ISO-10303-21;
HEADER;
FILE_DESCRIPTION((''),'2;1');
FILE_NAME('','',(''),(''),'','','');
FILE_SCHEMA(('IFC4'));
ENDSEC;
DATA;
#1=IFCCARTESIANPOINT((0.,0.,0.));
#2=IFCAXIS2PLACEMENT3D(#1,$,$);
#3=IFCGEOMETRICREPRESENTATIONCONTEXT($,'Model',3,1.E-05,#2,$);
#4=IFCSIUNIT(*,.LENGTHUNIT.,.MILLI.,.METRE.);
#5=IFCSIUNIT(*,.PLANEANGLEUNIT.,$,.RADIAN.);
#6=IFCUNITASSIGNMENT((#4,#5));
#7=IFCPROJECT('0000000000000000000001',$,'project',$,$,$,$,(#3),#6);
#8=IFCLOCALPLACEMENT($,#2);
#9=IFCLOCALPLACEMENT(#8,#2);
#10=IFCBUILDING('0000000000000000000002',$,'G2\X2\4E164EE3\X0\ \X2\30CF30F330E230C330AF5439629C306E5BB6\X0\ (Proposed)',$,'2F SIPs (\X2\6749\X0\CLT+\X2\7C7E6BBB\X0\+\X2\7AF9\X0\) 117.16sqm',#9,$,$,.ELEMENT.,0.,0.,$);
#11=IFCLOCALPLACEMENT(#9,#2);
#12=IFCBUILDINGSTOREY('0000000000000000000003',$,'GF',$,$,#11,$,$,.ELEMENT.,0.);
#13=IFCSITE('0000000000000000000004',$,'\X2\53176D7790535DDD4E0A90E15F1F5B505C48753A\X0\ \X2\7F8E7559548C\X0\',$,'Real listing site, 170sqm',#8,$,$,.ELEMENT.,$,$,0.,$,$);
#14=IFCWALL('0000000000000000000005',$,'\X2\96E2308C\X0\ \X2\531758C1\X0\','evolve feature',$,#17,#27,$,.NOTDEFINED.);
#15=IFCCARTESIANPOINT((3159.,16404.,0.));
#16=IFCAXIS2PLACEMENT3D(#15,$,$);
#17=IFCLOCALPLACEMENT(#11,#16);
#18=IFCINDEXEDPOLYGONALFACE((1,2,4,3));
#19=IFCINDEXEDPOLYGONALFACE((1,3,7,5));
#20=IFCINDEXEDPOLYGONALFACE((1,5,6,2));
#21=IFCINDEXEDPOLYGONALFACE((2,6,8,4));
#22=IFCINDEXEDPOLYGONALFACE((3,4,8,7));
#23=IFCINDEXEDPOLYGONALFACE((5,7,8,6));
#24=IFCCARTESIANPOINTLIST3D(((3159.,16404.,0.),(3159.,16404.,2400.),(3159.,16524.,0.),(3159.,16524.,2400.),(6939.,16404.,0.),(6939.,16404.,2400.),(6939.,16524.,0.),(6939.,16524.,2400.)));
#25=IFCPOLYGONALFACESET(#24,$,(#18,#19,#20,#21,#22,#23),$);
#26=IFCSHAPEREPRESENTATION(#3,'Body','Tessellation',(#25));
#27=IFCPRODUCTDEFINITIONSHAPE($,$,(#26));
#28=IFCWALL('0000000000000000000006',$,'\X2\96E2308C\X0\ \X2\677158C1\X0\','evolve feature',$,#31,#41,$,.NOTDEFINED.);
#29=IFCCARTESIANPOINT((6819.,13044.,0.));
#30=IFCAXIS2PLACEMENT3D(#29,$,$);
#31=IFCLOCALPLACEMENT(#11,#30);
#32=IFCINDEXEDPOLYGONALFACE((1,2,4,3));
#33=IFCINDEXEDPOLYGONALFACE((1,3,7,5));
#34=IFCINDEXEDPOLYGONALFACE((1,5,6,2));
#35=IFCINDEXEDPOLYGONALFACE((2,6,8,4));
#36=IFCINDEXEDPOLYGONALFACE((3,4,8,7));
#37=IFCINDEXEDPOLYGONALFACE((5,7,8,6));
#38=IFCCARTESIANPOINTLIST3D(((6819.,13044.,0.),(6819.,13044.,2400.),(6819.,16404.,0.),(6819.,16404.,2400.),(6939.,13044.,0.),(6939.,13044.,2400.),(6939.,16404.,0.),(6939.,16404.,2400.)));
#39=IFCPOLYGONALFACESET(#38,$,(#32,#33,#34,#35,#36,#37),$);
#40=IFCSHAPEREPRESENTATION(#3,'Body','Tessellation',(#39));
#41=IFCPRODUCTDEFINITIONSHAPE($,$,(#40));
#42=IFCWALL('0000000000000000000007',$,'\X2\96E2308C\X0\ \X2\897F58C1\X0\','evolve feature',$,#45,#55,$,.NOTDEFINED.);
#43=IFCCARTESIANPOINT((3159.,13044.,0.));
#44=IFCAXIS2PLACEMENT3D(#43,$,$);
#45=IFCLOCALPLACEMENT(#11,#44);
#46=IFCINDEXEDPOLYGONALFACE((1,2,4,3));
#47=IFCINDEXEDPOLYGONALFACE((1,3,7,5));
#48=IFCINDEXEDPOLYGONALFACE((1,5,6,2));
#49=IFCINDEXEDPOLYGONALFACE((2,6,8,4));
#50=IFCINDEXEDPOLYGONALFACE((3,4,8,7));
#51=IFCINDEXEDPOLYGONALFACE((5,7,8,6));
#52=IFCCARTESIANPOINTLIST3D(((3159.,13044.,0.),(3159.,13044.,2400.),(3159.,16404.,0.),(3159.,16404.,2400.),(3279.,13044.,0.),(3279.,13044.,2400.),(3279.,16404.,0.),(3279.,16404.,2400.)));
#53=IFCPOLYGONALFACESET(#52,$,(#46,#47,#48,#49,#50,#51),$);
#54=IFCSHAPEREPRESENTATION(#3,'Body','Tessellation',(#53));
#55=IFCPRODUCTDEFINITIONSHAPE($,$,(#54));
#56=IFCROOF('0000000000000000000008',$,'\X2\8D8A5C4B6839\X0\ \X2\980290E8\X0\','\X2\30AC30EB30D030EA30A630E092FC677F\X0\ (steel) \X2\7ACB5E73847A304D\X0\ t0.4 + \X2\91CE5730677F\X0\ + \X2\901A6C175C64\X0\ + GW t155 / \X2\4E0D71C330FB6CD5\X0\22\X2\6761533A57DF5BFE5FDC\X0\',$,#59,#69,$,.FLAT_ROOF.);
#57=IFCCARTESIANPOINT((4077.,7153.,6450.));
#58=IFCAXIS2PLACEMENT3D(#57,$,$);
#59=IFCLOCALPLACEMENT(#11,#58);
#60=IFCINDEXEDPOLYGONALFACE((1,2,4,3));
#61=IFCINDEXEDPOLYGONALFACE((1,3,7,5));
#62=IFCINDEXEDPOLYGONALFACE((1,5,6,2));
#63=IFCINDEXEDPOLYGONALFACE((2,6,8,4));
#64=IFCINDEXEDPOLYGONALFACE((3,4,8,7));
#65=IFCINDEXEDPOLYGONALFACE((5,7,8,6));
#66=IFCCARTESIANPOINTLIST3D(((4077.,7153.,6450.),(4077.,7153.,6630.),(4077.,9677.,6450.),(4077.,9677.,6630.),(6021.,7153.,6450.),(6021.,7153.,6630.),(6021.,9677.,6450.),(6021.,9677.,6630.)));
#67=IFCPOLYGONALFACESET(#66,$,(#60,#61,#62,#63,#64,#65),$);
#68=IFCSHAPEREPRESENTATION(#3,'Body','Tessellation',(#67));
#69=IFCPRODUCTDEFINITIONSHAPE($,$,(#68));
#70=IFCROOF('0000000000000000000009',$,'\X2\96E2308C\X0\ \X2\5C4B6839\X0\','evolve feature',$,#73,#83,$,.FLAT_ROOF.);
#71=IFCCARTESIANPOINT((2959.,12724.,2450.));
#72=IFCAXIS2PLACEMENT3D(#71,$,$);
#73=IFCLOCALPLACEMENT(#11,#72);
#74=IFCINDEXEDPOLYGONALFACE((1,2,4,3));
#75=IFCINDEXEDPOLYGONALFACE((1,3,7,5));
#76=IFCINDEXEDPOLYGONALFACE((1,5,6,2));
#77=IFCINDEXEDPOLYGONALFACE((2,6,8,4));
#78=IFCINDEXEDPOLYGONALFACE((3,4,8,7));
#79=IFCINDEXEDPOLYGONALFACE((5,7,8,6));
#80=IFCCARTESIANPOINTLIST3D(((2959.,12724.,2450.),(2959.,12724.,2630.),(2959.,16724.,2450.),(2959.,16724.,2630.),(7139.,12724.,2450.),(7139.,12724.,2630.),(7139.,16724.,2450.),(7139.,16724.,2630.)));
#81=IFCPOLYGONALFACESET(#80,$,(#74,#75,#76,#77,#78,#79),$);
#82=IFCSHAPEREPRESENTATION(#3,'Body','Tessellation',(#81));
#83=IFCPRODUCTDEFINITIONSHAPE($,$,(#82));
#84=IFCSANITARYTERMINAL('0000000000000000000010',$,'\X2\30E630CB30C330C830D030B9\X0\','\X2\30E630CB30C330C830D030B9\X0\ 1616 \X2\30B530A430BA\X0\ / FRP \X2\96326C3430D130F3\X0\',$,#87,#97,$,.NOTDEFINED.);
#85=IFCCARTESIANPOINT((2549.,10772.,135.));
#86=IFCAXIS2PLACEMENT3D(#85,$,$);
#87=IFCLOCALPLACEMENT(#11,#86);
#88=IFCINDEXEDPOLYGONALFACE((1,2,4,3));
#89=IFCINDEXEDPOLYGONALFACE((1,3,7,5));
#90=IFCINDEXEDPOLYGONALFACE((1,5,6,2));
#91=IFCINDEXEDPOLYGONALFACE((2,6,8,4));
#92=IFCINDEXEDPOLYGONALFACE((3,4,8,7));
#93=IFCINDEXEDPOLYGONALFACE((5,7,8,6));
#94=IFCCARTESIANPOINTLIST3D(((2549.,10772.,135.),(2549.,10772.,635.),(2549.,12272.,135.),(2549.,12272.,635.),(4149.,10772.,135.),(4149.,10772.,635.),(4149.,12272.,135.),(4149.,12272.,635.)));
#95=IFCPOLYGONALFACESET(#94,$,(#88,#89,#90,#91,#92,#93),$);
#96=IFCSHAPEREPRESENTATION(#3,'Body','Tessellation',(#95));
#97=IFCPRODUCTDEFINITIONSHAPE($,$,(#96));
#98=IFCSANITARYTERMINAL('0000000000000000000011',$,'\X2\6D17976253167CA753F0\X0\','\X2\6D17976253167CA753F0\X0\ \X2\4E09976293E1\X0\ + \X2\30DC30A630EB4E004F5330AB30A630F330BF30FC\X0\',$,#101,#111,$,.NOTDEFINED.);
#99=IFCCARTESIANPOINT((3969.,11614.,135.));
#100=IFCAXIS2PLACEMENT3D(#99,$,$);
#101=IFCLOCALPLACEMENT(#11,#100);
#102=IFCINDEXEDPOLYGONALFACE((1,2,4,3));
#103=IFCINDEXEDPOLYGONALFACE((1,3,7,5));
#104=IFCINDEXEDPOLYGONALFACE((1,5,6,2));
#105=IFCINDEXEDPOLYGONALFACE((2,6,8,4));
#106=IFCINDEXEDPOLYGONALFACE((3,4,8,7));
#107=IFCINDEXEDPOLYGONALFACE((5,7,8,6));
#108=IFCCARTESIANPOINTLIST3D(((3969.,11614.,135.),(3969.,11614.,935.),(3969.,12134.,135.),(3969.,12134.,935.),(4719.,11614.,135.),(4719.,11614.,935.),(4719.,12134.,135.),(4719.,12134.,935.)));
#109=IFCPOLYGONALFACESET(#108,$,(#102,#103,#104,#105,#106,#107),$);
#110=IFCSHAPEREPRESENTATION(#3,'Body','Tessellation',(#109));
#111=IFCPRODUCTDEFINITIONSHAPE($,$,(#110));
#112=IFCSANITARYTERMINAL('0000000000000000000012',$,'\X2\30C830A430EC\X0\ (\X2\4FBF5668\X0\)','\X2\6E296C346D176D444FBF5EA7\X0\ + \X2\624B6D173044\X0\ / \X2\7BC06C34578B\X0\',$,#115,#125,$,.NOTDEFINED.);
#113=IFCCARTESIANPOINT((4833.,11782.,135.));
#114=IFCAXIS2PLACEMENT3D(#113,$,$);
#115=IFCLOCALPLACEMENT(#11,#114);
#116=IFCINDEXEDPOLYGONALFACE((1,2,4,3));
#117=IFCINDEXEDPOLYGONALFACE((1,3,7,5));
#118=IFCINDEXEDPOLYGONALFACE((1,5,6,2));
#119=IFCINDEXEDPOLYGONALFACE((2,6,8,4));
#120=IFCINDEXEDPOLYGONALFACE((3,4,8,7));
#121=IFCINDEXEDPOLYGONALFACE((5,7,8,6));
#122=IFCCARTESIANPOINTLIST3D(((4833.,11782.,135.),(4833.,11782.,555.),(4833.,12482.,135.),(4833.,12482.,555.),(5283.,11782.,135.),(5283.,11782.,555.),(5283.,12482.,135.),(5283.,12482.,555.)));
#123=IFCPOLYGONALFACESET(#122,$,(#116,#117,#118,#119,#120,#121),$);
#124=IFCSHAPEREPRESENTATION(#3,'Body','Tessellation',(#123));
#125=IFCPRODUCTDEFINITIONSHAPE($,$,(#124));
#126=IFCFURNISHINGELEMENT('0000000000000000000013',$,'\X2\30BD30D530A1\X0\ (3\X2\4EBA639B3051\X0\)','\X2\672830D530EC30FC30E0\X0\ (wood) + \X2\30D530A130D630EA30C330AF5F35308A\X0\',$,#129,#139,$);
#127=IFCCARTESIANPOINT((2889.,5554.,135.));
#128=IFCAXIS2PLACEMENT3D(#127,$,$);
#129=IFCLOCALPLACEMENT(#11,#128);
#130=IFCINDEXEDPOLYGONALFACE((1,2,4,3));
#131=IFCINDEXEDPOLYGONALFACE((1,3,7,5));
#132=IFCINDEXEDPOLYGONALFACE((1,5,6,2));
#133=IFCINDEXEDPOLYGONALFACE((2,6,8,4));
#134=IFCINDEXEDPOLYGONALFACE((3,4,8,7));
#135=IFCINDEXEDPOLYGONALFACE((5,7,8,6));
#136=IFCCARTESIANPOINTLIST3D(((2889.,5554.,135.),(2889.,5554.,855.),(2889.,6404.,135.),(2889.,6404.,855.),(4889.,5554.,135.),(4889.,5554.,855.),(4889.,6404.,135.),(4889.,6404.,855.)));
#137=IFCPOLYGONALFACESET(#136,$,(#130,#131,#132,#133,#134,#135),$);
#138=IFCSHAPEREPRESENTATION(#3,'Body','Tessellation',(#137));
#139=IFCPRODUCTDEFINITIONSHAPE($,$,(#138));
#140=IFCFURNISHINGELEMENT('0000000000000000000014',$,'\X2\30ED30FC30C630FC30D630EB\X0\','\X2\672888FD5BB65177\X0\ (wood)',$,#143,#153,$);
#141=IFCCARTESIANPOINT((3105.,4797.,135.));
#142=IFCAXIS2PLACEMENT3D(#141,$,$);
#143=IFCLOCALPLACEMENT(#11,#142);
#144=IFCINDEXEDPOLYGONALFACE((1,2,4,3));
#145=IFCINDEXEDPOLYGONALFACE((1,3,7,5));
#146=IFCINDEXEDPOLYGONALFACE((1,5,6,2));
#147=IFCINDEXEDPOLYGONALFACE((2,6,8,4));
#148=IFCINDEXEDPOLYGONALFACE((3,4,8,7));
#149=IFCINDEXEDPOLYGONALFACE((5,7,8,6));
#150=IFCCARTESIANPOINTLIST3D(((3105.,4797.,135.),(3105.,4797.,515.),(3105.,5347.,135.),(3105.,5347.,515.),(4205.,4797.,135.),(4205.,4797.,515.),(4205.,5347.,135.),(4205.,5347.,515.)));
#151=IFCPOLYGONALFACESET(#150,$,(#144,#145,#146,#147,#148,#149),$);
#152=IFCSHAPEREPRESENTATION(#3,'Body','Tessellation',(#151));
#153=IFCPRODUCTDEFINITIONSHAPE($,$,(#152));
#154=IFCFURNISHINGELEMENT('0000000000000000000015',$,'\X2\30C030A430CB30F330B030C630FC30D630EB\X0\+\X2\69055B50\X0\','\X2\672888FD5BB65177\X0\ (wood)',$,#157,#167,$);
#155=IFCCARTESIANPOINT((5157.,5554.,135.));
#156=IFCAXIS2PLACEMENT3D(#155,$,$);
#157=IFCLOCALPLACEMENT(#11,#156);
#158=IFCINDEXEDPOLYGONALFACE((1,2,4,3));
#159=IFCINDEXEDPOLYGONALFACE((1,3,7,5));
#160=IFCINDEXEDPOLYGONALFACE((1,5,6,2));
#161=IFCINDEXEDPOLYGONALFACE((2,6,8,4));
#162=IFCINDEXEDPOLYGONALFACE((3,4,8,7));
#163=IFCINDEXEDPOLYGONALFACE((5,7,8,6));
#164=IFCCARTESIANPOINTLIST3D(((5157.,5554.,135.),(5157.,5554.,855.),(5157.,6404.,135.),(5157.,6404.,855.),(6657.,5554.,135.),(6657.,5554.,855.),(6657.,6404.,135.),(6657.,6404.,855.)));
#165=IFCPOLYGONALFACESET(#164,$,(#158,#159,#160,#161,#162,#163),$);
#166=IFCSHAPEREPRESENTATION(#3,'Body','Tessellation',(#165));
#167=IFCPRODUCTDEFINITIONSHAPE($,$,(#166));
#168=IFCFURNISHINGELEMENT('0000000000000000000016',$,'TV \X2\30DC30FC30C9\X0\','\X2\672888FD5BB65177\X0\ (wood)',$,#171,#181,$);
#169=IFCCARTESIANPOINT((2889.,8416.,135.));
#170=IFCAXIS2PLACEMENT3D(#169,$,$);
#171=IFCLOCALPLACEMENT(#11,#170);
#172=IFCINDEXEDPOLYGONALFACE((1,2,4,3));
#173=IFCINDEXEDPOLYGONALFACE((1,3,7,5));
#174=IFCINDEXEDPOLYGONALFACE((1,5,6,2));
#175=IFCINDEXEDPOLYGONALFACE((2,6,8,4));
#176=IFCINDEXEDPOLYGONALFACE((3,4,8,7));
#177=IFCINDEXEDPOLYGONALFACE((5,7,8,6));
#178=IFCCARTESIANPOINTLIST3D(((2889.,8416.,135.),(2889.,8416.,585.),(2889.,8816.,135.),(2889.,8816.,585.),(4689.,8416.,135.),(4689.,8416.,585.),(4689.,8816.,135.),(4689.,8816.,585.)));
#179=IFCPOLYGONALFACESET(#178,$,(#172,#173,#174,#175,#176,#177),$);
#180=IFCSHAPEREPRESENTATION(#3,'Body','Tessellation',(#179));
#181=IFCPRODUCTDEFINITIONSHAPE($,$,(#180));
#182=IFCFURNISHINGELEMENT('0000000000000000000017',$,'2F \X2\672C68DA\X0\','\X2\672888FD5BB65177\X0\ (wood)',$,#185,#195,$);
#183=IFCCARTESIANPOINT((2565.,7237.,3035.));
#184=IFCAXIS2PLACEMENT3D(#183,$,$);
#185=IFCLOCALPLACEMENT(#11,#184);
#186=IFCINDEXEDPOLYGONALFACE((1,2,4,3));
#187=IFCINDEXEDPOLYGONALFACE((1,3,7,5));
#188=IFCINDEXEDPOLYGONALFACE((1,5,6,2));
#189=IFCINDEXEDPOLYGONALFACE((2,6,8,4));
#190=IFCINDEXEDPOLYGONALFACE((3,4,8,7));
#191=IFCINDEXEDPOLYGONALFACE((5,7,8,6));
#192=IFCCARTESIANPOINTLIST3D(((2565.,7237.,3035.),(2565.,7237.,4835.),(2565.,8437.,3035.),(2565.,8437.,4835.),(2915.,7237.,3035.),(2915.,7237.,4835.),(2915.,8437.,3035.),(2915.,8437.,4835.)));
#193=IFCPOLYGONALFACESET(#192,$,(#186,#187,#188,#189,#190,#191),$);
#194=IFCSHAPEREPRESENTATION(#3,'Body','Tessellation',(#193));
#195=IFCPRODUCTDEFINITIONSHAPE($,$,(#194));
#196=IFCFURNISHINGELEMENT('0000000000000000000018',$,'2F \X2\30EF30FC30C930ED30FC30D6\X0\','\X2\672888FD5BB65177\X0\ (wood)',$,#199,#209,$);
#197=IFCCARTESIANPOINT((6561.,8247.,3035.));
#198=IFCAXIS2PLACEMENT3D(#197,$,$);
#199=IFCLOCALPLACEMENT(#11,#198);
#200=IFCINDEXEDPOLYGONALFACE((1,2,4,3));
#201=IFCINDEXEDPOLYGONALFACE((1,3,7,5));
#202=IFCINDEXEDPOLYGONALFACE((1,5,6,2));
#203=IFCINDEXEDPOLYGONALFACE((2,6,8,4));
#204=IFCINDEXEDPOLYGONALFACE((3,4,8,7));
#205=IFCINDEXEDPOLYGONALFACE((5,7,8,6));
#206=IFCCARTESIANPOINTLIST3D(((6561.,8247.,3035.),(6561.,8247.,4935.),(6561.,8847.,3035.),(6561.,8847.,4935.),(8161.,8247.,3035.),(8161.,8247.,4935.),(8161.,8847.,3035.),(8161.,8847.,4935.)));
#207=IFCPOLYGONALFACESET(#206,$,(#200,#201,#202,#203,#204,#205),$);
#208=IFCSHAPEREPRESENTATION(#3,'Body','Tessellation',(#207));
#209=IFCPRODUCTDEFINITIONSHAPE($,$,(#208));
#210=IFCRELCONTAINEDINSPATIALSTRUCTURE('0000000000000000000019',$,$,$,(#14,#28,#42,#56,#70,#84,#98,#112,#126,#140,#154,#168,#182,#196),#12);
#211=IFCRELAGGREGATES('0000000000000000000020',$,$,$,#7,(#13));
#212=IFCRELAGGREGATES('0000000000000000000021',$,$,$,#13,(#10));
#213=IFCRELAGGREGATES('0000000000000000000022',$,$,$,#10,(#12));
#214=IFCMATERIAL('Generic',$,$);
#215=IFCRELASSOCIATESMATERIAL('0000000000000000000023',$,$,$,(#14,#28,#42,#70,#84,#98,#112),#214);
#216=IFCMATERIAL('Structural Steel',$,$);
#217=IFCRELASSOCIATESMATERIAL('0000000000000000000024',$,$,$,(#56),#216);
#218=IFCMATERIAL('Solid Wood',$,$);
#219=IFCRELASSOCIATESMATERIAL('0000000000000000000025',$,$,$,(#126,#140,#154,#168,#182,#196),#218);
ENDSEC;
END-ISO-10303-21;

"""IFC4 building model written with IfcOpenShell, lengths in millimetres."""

from ifc_helpers import new_model, si_unit, frame, frame_2d, origin, place, context, project, spatial, rectangle, extrude, material, element, save


model = new_model("IFC4")

# Units and contexts
model_context = context("Model", 3, precision=1e-05, world=origin())
ifc_project = project(units=[si_unit("LENGTHUNIT", "METRE", prefix="MILLI"), si_unit("PLANEANGLEUNIT", "RADIAN")], contexts=[model_context])

# Site, building, storey
site_placement = place(None, origin())
site = spatial("IfcSite", under=ifc_project, at=site_placement, Name="北海道川上郡弟子屈町 美留和", ObjectType="Real listing site, 170sqm", CompositionType="ELEMENT", RefElevation=0.0)
building_placement = place(site_placement, origin())
building = spatial("IfcBuilding", under=site, at=building_placement, Name="G2世代 ハンモック吹抜の家 (Proposed)", ObjectType="2F SIPs (杉CLT+籾殻+竹) 117.16sqm", CompositionType="ELEMENT", ElevationOfRefHeight=0.0, ElevationOfTerrain=0.0)
storey_placement = place(building_placement, origin())
storey = spatial("IfcBuildingStorey", under=building, at=storey_placement, Name="GF", CompositionType="ELEMENT", Elevation=0.0)

# Shared definitions
ifc_material_1 = material(Name="Generic")

# Shared definitions
ifc_material_2 = material(Name="Solid Wood")

# Walls
wall_1_placement = place(storey_placement, frame((3159.0, 16404.0, 0.0)))
element("IfcWall", 1, at=wall_1_placement, inside=storey, material=ifc_material_1, Name="離れ 北壁", Description="evolve feature", PredefinedType="NOTDEFINED", context=model_context, shape_type="SweptSolid", body=[
    extrude(rectangle(XDim=3780.0, YDim=120.0, at=frame_2d((1890.0, 60.0))), frame((3159.0, 16404.0, 0.0)), (0.0, 0.0, 1.0), 2400.0),
])
wall_2_placement = place(storey_placement, frame((6819.0, 13044.0, 0.0)))
element("IfcWall", 2, at=wall_2_placement, inside=storey, material=ifc_material_1, Name="離れ 東壁", Description="evolve feature", PredefinedType="NOTDEFINED", context=model_context, shape_type="SweptSolid", body=[
    extrude(rectangle(XDim=120.0, YDim=3360.0, at=frame_2d((60.0, 1680.0))), frame((6819.0, 13044.0, 0.0)), (0.0, 0.0, 1.0), 2400.0),
])
wall_3_placement = place(storey_placement, frame((3159.0, 13044.0, 0.0)))
element("IfcWall", 3, at=wall_3_placement, inside=storey, material=ifc_material_1, Name="離れ 西壁", Description="evolve feature", PredefinedType="NOTDEFINED", context=model_context, shape_type="SweptSolid", body=[
    extrude(rectangle(XDim=120.0, YDim=3360.0, at=frame_2d((60.0, 1680.0))), frame((3159.0, 13044.0, 0.0)), (0.0, 0.0, 1.0), 2400.0),
])

# Roofs
ifc_material_3 = material(Name="Structural Steel")
roof_1_placement = place(storey_placement, frame((4077.0, 7153.0, 6450.0)))
element("IfcRoof", 4, at=roof_1_placement, inside=storey, material=ifc_material_3, Name="越屋根 頂部", Description="ガルバリウム鋼板 (steel) 立平葺き t0.4 + 野地板 + 通気層 + GW t155 / 不燃・法22条区域対応", PredefinedType="FLAT_ROOF", context=model_context, shape_type="SweptSolid", body=[
    extrude(rectangle(XDim=1944.0, YDim=2524.0, at=frame_2d((972.0, 1262.0))), frame((4077.0, 7153.0, 6450.0)), (0.0, 0.0, 1.0), 180.0),
])
roof_2_placement = place(storey_placement, frame((2959.0, 12724.0, 2450.0)))
element("IfcRoof", 5, at=roof_2_placement, inside=storey, material=ifc_material_1, Name="離れ 屋根", Description="evolve feature", PredefinedType="FLAT_ROOF", context=model_context, shape_type="SweptSolid", body=[
    extrude(rectangle(XDim=4180.0, YDim=4000.0, at=frame_2d((2090.0, 2000.0))), frame((2959.0, 12724.0, 2450.0)), (0.0, 0.0, 1.0), 180.0),
])

# Sanitary terminals
sanitary_terminal_1_placement = place(storey_placement, frame((2549.0, 10772.0, 135.0)))
element("IfcSanitaryTerminal", 6, at=sanitary_terminal_1_placement, inside=storey, material=ifc_material_1, Name="ユニットバス", Description="ユニットバス 1616 サイズ / FRP 防水パン", PredefinedType="NOTDEFINED", context=model_context, shape_type="SweptSolid", body=[
    extrude(rectangle(XDim=1600.0, YDim=1500.0, at=frame_2d((800.0, 750.0))), frame((2549.0, 10772.0, 135.0)), (0.0, 0.0, 1.0), 500.0),
])
sanitary_terminal_2_placement = place(storey_placement, frame((3969.0, 11614.0, 135.0)))
element("IfcSanitaryTerminal", 7, at=sanitary_terminal_2_placement, inside=storey, material=ifc_material_1, Name="洗面化粧台", Description="洗面化粧台 三面鏡 + ボウル一体カウンター", PredefinedType="NOTDEFINED", context=model_context, shape_type="SweptSolid", body=[
    extrude(rectangle(XDim=750.0, YDim=520.0, at=frame_2d((375.0, 260.0))), frame((3969.0, 11614.0, 135.0)), (0.0, 0.0, 1.0), 800.0),
])
sanitary_terminal_3_placement = place(storey_placement, frame((4833.0, 11782.0, 135.0)))
element("IfcSanitaryTerminal", 8, at=sanitary_terminal_3_placement, inside=storey, material=ifc_material_1, Name="トイレ (便器)", Description="温水洗浄便座 + 手洗い / 節水型", PredefinedType="NOTDEFINED", context=model_context, shape_type="SweptSolid", body=[
    extrude(rectangle(XDim=450.0, YDim=700.0, at=frame_2d((225.0, 350.0))), frame((4833.0, 11782.0, 135.0)), (0.0, 0.0, 1.0), 420.0),
])

# Furnishing elements
furnishing_1_placement = place(storey_placement, frame((2889.0, 5554.0, 135.0)))
element("IfcFurnishingElement", 9, at=furnishing_1_placement, inside=storey, material=ifc_material_2, Name="ソファ (3人掛け)", Description="木フレーム (wood) + ファブリック張り", context=model_context, shape_type="SweptSolid", body=[
    extrude(rectangle(XDim=2000.0, YDim=850.0, at=frame_2d((1000.0, 425.0))), frame((2889.0, 5554.0, 135.0)), (0.0, 0.0, 1.0), 720.0),
])
furnishing_2_placement = place(storey_placement, frame((3105.0, 4797.0, 135.0)))
element("IfcFurnishingElement", 10, at=furnishing_2_placement, inside=storey, material=ifc_material_2, Name="ローテーブル", Description="木製家具 (wood)", context=model_context, shape_type="SweptSolid", body=[
    extrude(rectangle(XDim=1100.0, YDim=550.0, at=frame_2d((550.0, 275.0))), frame((3105.0, 4797.0, 135.0)), (0.0, 0.0, 1.0), 380.0),
])
furnishing_3_placement = place(storey_placement, frame((5157.0, 5554.0, 135.0)))
element("IfcFurnishingElement", 11, at=furnishing_3_placement, inside=storey, material=ifc_material_2, Name="ダイニングテーブル+椅子", Description="木製家具 (wood)", context=model_context, shape_type="SweptSolid", body=[
    extrude(rectangle(XDim=1500.0, YDim=850.0, at=frame_2d((750.0, 425.0))), frame((5157.0, 5554.0, 135.0)), (0.0, 0.0, 1.0), 720.0),
])
furnishing_4_placement = place(storey_placement, frame((2889.0, 8416.0, 135.0)))
element("IfcFurnishingElement", 12, at=furnishing_4_placement, inside=storey, material=ifc_material_2, Name="TV ボード", Description="木製家具 (wood)", context=model_context, shape_type="SweptSolid", body=[
    extrude(rectangle(XDim=1800.0, YDim=400.0, at=frame_2d((900.0, 200.0))), frame((2889.0, 8416.0, 135.0)), (0.0, 0.0, 1.0), 450.0),
])
furnishing_5_placement = place(storey_placement, frame((2565.0, 7237.0, 3035.0)))
element("IfcFurnishingElement", 13, at=furnishing_5_placement, inside=storey, material=ifc_material_2, Name="2F 本棚", Description="木製家具 (wood)", context=model_context, shape_type="SweptSolid", body=[
    extrude(rectangle(XDim=350.0, YDim=1200.0, at=frame_2d((175.0, 600.0))), frame((2565.0, 7237.0, 3035.0)), (0.0, 0.0, 1.0), 1800.0),
])
furnishing_6_placement = place(storey_placement, frame((6561.0, 8247.0, 3035.0)))
element("IfcFurnishingElement", 14, at=furnishing_6_placement, inside=storey, material=ifc_material_2, Name="2F ワードローブ", Description="木製家具 (wood)", context=model_context, shape_type="SweptSolid", body=[
    extrude(rectangle(XDim=1600.0, YDim=600.0, at=frame_2d((800.0, 300.0))), frame((6561.0, 8247.0, 3035.0)), (0.0, 0.0, 1.0), 1900.0),
])

save(model, "model.ifc")
